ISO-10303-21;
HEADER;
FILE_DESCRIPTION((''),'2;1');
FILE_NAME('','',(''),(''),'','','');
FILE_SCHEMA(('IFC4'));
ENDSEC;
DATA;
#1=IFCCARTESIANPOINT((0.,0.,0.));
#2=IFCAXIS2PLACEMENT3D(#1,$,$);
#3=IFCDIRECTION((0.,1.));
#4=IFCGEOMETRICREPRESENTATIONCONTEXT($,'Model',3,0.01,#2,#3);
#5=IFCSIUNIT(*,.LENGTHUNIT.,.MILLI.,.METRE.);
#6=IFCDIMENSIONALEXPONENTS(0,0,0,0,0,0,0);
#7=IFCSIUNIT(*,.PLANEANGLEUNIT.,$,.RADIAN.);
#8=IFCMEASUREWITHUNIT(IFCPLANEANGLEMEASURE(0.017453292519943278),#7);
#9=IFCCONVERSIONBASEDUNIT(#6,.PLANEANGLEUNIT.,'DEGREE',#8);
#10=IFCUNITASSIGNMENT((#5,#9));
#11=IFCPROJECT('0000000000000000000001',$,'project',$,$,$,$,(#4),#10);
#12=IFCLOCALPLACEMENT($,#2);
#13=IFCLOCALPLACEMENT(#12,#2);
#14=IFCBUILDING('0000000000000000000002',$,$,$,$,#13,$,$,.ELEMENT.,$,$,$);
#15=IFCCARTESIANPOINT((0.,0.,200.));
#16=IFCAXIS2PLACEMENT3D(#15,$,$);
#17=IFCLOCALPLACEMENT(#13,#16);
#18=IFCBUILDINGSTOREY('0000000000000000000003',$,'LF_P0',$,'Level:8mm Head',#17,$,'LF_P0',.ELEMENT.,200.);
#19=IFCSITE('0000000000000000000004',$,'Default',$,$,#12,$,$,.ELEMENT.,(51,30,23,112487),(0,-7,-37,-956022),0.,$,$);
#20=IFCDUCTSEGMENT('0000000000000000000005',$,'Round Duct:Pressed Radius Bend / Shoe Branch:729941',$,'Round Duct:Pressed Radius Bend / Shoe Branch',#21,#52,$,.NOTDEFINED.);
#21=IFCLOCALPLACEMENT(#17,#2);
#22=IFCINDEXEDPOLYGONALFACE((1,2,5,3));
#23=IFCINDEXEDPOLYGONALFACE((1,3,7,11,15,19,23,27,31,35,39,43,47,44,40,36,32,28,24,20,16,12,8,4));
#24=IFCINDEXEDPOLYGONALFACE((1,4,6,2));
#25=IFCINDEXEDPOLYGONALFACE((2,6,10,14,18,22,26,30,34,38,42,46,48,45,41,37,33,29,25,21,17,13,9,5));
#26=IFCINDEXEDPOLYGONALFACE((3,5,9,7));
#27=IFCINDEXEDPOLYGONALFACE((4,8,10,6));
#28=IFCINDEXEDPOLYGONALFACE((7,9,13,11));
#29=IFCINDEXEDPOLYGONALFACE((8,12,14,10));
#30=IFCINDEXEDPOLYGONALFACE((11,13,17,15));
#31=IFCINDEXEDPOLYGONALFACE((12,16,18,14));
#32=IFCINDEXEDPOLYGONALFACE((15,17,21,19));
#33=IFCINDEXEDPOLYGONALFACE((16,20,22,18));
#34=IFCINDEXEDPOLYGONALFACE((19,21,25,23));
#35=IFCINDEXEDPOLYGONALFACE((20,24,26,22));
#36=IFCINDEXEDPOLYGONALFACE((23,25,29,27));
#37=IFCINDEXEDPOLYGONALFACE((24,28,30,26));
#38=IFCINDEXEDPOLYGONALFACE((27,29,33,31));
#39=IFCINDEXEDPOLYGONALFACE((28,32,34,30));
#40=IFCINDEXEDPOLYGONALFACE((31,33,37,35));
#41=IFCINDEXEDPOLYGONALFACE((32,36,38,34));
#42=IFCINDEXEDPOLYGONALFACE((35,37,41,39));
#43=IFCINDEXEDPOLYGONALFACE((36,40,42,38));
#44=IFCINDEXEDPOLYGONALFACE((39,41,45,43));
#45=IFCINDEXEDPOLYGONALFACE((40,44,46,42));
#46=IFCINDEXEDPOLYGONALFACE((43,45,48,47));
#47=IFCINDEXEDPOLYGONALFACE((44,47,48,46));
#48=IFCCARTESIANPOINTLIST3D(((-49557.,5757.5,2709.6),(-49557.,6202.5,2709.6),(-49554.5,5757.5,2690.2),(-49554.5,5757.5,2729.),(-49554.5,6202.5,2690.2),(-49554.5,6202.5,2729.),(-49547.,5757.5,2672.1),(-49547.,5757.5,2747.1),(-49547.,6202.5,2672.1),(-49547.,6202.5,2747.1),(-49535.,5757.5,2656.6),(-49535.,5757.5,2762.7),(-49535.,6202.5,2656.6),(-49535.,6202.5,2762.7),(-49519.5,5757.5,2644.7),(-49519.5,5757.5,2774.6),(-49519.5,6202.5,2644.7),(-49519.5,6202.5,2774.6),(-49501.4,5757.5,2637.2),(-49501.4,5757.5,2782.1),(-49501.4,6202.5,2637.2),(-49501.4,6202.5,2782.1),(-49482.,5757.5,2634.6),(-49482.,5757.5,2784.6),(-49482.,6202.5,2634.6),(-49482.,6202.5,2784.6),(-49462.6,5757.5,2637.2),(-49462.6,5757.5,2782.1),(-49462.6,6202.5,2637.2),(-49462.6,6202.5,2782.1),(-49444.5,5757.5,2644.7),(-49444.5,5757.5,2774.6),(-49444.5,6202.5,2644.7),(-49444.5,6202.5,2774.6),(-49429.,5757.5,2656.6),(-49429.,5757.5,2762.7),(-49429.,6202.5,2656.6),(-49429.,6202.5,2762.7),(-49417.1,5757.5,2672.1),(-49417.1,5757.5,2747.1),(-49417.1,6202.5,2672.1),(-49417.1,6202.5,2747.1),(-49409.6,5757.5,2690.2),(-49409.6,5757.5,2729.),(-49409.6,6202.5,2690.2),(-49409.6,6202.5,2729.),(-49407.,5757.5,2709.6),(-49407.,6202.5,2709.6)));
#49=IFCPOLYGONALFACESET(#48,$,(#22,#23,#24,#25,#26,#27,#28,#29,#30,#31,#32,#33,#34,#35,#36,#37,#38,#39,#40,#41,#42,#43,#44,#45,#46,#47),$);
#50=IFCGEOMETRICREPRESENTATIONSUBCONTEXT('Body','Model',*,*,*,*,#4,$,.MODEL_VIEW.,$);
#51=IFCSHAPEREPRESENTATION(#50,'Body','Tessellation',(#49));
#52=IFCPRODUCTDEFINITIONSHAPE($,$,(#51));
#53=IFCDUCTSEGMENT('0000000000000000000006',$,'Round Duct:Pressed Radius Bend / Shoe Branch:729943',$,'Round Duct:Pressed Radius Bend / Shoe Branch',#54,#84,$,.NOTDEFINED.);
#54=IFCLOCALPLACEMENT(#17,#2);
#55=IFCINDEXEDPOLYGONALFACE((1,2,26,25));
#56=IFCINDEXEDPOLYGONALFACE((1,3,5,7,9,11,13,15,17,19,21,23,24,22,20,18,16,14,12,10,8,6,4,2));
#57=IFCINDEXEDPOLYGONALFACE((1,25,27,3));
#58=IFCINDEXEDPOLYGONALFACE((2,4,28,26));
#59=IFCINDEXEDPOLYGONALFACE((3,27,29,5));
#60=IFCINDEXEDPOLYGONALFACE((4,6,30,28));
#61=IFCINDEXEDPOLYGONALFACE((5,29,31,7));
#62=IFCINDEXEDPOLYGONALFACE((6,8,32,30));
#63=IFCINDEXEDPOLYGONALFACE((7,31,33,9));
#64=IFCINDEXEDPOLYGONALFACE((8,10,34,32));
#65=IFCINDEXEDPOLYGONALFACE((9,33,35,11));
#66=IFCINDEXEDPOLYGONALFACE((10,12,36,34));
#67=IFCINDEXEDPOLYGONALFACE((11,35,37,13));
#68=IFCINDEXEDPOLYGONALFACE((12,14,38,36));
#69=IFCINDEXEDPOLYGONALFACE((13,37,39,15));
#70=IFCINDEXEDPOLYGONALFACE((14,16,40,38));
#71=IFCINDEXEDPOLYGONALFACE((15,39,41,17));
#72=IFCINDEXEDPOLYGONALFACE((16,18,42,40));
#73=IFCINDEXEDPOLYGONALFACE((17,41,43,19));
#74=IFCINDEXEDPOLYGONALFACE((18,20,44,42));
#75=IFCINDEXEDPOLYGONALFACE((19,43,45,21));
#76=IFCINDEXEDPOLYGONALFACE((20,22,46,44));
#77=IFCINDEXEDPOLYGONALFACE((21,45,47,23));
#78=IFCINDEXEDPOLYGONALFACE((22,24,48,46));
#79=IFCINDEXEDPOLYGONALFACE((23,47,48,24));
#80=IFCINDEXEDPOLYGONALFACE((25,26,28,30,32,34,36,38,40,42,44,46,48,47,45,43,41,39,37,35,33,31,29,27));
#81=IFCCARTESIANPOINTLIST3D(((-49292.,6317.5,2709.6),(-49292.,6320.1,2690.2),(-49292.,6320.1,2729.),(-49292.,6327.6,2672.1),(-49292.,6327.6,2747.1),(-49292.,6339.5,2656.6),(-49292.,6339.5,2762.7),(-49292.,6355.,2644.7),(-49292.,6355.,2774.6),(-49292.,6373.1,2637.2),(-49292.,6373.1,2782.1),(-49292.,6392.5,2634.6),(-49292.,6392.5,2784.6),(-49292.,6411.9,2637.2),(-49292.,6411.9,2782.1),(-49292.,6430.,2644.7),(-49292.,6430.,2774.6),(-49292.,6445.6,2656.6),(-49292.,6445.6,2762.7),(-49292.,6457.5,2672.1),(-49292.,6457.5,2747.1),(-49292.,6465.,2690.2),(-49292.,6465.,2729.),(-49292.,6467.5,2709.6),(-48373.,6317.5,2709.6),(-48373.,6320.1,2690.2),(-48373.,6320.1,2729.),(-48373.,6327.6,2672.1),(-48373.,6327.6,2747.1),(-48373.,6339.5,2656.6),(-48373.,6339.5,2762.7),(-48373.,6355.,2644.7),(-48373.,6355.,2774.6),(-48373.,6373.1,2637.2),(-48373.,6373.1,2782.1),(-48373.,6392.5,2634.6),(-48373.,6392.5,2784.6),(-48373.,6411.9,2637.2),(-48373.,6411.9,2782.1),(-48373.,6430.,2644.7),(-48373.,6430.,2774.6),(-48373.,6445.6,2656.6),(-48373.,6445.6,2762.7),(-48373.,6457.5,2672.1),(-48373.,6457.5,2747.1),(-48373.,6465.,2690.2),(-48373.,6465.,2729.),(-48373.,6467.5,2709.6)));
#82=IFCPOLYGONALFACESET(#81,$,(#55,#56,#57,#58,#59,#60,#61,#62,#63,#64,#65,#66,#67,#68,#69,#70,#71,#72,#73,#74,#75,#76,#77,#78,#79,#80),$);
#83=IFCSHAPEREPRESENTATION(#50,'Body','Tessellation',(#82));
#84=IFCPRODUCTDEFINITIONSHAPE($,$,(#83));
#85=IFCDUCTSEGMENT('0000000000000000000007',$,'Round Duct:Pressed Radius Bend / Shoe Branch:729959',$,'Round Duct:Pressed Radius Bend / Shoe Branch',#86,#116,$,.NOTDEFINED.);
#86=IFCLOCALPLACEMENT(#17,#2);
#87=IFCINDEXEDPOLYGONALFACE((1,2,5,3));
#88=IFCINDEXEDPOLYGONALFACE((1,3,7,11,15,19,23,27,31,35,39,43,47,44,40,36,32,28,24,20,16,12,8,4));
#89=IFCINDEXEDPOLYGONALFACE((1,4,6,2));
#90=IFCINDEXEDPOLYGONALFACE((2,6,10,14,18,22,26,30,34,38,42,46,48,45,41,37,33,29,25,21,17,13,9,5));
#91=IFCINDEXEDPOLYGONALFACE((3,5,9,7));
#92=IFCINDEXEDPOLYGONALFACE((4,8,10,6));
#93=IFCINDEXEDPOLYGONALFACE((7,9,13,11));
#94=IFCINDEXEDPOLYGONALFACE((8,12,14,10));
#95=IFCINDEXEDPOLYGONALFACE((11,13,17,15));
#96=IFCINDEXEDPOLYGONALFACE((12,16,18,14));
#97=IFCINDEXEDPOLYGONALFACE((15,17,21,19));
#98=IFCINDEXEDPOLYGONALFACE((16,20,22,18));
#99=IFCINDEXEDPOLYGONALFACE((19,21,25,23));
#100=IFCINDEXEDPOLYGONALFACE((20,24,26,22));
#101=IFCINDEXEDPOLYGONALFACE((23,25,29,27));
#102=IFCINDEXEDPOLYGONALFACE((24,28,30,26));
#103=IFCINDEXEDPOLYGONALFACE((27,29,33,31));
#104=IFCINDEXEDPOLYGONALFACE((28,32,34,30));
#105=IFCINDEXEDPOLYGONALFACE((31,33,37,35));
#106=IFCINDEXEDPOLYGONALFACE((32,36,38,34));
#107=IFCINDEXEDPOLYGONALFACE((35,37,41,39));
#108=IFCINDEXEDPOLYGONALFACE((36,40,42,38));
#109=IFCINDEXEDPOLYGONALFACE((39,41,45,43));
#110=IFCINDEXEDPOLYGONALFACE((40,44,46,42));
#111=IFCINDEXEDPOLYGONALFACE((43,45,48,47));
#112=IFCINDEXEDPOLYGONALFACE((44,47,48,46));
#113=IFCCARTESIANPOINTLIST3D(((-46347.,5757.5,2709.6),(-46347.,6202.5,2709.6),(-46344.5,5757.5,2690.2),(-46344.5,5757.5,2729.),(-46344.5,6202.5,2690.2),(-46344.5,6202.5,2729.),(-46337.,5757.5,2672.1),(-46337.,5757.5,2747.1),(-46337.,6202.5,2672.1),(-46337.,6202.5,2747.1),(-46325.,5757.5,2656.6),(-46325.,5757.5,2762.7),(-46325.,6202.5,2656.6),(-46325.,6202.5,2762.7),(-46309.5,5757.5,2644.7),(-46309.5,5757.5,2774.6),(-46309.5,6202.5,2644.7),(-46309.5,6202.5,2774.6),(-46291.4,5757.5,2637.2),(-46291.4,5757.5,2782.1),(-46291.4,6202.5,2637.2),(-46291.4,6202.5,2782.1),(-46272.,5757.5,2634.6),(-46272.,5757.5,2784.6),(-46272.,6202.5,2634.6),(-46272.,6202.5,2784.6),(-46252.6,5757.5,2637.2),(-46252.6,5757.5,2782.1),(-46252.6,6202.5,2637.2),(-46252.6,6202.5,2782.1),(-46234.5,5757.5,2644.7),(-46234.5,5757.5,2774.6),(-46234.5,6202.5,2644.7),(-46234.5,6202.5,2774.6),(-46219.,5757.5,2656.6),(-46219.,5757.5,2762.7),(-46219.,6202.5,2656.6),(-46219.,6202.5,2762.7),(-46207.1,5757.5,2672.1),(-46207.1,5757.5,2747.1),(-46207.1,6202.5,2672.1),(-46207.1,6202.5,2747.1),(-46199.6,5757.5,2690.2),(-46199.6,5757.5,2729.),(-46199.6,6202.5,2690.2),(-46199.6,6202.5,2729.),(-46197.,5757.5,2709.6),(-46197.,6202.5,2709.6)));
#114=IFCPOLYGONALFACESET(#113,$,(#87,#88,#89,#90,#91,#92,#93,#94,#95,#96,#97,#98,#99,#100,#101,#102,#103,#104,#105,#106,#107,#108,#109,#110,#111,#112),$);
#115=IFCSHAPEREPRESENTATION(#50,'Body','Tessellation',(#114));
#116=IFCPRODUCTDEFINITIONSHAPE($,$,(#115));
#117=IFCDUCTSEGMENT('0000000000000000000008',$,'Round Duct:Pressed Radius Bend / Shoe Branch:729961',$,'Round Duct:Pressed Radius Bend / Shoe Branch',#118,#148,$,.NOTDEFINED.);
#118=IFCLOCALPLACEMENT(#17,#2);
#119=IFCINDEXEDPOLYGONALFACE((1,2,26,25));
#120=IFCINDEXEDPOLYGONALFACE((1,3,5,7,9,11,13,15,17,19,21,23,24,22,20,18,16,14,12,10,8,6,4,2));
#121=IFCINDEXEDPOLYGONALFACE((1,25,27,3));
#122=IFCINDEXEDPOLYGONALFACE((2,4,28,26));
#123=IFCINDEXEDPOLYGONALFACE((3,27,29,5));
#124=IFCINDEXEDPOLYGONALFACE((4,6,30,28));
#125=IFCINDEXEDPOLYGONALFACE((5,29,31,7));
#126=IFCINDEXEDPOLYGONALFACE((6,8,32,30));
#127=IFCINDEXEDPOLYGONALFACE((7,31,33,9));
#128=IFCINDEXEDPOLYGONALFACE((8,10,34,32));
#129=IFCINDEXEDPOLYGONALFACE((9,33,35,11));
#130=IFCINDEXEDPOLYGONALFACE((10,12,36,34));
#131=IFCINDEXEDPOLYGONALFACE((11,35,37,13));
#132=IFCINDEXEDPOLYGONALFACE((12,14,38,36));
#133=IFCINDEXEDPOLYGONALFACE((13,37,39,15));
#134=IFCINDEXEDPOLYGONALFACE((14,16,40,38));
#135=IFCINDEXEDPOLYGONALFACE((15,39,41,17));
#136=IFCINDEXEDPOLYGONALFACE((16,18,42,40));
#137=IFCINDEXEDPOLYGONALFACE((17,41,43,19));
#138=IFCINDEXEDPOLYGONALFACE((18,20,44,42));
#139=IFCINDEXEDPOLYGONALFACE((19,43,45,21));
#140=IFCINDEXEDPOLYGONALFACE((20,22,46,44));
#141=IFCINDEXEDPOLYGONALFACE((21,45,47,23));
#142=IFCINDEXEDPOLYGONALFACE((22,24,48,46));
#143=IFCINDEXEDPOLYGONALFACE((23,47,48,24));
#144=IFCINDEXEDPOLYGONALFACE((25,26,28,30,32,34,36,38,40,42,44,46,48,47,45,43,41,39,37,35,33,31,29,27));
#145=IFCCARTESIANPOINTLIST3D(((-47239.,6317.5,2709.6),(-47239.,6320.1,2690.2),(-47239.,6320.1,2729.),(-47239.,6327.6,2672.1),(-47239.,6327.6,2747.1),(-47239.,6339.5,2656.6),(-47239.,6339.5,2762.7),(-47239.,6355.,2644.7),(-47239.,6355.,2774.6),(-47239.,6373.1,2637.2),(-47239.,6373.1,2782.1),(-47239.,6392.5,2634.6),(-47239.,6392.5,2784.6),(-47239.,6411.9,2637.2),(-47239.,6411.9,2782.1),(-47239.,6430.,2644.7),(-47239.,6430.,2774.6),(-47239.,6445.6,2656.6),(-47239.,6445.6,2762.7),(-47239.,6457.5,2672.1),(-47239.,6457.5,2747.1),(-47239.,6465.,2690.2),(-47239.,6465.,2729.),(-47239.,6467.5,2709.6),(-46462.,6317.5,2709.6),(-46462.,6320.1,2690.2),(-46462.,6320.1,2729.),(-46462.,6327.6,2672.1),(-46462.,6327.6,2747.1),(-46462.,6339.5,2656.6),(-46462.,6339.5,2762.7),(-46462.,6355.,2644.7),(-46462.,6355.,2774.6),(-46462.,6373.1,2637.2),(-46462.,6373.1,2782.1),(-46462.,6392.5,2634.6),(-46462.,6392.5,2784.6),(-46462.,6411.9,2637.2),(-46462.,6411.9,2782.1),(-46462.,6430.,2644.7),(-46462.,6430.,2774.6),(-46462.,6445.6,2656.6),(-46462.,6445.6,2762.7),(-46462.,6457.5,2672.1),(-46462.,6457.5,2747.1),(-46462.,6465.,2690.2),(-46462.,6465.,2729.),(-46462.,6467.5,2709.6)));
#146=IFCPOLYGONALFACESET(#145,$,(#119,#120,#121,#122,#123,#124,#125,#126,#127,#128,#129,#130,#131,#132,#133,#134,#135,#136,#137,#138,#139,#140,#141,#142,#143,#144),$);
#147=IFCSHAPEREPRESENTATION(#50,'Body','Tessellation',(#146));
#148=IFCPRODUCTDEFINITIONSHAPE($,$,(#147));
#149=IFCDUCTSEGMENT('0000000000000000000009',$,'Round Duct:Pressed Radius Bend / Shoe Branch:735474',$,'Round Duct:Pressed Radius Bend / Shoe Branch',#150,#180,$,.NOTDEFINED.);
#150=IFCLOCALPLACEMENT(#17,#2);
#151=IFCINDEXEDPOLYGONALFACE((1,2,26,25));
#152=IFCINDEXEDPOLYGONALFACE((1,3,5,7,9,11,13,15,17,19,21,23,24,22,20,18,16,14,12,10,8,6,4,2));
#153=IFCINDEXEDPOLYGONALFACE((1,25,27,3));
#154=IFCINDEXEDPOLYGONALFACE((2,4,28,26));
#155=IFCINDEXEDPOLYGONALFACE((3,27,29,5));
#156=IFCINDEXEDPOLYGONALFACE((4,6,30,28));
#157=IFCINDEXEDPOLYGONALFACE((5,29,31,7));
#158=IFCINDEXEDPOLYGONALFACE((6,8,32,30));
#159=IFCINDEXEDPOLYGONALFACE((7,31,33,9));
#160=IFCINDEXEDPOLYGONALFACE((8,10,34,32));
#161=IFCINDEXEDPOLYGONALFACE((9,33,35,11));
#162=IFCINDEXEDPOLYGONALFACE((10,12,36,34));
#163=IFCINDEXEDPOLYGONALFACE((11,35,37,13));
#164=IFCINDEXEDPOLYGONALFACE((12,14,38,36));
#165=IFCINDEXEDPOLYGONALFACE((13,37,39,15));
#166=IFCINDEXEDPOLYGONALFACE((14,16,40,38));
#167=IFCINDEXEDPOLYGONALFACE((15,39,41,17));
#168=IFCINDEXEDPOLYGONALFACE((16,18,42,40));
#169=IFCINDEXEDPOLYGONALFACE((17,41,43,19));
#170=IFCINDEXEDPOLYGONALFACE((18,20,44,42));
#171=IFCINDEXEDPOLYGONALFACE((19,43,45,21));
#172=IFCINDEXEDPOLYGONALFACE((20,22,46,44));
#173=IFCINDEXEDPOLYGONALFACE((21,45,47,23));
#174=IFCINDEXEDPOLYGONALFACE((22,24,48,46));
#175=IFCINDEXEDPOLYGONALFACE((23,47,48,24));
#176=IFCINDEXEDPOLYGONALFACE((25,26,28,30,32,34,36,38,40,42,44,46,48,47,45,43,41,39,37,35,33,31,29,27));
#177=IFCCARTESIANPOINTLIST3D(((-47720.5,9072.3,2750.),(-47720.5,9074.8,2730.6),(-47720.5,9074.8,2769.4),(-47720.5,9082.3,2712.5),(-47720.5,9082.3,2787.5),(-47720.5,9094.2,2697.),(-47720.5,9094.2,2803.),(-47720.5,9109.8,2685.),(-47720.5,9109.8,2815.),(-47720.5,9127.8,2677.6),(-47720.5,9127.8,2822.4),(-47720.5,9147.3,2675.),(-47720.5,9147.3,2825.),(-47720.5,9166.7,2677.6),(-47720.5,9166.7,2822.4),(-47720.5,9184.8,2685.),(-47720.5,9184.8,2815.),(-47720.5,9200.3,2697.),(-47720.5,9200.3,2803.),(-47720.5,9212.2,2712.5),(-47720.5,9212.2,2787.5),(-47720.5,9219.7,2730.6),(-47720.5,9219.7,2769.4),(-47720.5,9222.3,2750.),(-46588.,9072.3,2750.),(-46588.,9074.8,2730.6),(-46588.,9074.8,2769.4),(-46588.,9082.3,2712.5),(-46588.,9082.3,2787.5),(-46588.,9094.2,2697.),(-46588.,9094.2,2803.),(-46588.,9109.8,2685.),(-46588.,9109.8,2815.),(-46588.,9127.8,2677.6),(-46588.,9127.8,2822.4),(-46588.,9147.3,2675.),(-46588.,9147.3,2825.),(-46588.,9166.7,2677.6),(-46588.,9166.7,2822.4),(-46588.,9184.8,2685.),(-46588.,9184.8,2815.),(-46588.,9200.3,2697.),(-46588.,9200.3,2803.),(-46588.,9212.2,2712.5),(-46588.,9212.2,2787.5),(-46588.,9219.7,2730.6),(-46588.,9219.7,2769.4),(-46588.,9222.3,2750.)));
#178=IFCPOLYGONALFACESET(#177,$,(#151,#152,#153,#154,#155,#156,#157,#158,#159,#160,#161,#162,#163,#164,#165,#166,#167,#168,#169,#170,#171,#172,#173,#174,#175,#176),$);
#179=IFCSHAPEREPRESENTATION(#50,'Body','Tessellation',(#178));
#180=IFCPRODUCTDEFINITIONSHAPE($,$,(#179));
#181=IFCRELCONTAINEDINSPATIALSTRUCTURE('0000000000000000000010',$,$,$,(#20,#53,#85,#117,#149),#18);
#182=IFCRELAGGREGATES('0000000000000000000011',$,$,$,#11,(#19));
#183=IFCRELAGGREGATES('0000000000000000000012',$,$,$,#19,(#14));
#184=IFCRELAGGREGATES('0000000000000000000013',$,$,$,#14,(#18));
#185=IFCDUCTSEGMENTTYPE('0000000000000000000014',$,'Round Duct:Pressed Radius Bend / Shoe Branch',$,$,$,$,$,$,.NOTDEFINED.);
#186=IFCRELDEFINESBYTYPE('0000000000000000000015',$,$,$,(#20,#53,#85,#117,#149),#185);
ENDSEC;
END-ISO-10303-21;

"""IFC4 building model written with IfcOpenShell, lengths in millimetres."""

from ifc_helpers import new_model, entity, si_unit, converted_unit, direction, frame, origin, place, context, subcontext, project, spatial, arc, indexed_curve, outline, extrude, type_object, element, save


model = new_model("IFC4")

# Units and contexts
model_context = context("Model", 3, precision=0.01, world=origin(), true_north=direction((0.0, 1.0)))
body_context = subcontext(model_context, "Body", "Model", "MODEL_VIEW")
ifc_project = project(units=[si_unit("LENGTHUNIT", "METRE", prefix="MILLI"), converted_unit("PLANEANGLEUNIT", "DEGREE", entity("IfcPlaneAngleMeasure", 0.017453292519943278), si_unit("PLANEANGLEUNIT", "RADIAN"), dimensions=[0, 0, 0, 0, 0, 0, 0])], contexts=[model_context])

# Site, building, storey
site_placement = place(None, origin())
site = spatial("IfcSite", under=ifc_project, at=site_placement, Name="Default", CompositionType="ELEMENT", RefLatitude=(51, 30, 23, 112487), RefLongitude=(0, -7, -37, -956022), RefElevation=0.0)
building_placement = place(site_placement, origin())
building = spatial("IfcBuilding", under=site, at=building_placement, CompositionType="ELEMENT")
storey_placement = place(building_placement, frame((0.0, 0.0, 200.0)))
storey = spatial("IfcBuildingStorey", under=building, at=storey_placement, Name="LF_P0", ObjectType="Level:8mm Head", LongName="LF_P0", CompositionType="ELEMENT", Elevation=200.0)

# Duct segments
duct_segment_type_1 = type_object("IfcDuctSegmentType", Name="Round Duct:Pressed Radius Bend / Shoe Branch", PredefinedType="NOTDEFINED")
duct_segment_1_placement = place(storey_placement, origin())
element("IfcDuctSegment", 1, at=duct_segment_1_placement, inside=storey, type_object=duct_segment_type_1, Name="Round Duct:Pressed Radius Bend / Shoe Branch:729941", ObjectType="Round Duct:Pressed Radius Bend / Shoe Branch", PredefinedType="NOTDEFINED", context=body_context, shape_type="SweptSolid", body=[
    extrude(outline(indexed_curve([(75.0, 0.0), (53.0, 53.0), (0.0, 75.0), (-53.0, 53.0), (-75.0, 0.0), (-53.0, -53.0), (0.0, -75.0), (53.0, -53.0)], segments=[arc(1, 2, 3), arc(3, 4, 5), arc(5, 6, 7), arc(7, 8, 1)], self_intersect=False)), frame((-49482.0, 5757.5, 2709.6), z_axis=(0.0, 1.0, 0.0), x_axis=(1.0, 0.0, 0.0)), (0.0, 0.0, 1.0), 445.0),
])
duct_segment_2_placement = place(storey_placement, origin())
element("IfcDuctSegment", 2, at=duct_segment_2_placement, inside=storey, type_object=duct_segment_type_1, Name="Round Duct:Pressed Radius Bend / Shoe Branch:729943", ObjectType="Round Duct:Pressed Radius Bend / Shoe Branch", PredefinedType="NOTDEFINED", context=body_context, shape_type="SweptSolid", body=[
    extrude(outline(indexed_curve([(75.0, 0.0), (53.0, 53.0), (0.0, 75.0), (-53.0, 53.0), (-75.0, 0.0), (-53.0, -53.0), (0.0, -75.0), (53.0, -53.0)], segments=[arc(1, 2, 3), arc(3, 4, 5), arc(5, 6, 7), arc(7, 8, 1)], self_intersect=False)), frame((-49292.0, 6392.5, 2709.6), z_axis=(1.0, 0.0, 0.0), x_axis=(0.0, 1.0, 0.0)), (0.0, 0.0, 1.0), 919.0),
])
duct_segment_3_placement = place(storey_placement, origin())
element("IfcDuctSegment", 3, at=duct_segment_3_placement, inside=storey, type_object=duct_segment_type_1, Name="Round Duct:Pressed Radius Bend / Shoe Branch:729959", ObjectType="Round Duct:Pressed Radius Bend / Shoe Branch", PredefinedType="NOTDEFINED", context=body_context, shape_type="SweptSolid", body=[
    extrude(outline(indexed_curve([(75.0, 0.0), (53.0, 53.0), (0.0, 75.0), (-53.0, 53.0), (-75.0, 0.0), (-53.0, -53.0), (0.0, -75.0), (53.0, -53.0)], segments=[arc(1, 2, 3), arc(3, 4, 5), arc(5, 6, 7), arc(7, 8, 1)], self_intersect=False)), frame((-46272.0, 5757.5, 2709.6), z_axis=(0.0, 1.0, 0.0), x_axis=(1.0, 0.0, 0.0)), (0.0, 0.0, 1.0), 445.0),
])
duct_segment_4_placement = place(storey_placement, origin())
element("IfcDuctSegment", 4, at=duct_segment_4_placement, inside=storey, type_object=duct_segment_type_1, Name="Round Duct:Pressed Radius Bend / Shoe Branch:729961", ObjectType="Round Duct:Pressed Radius Bend / Shoe Branch", PredefinedType="NOTDEFINED", context=body_context, shape_type="SweptSolid", body=[
    extrude(outline(indexed_curve([(75.0, 0.0), (53.0, 53.0), (0.0, 75.0), (-53.0, 53.0), (-75.0, 0.0), (-53.0, -53.0), (0.0, -75.0), (53.0, -53.0)], segments=[arc(1, 2, 3), arc(3, 4, 5), arc(5, 6, 7), arc(7, 8, 1)], self_intersect=False)), frame((-47239.0, 6392.5, 2709.6), z_axis=(1.0, 0.0, 0.0), x_axis=(0.0, -1.0, 0.0)), (0.0, 0.0, 1.0), 777.0),
])
duct_segment_5_placement = place(storey_placement, origin())
element("IfcDuctSegment", 5, at=duct_segment_5_placement, inside=storey, type_object=duct_segment_type_1, Name="Round Duct:Pressed Radius Bend / Shoe Branch:735474", ObjectType="Round Duct:Pressed Radius Bend / Shoe Branch", PredefinedType="NOTDEFINED", context=body_context, shape_type="SweptSolid", body=[
    extrude(outline(indexed_curve([(75.0, 0.0), (53.0, 53.0), (0.0, 75.0), (-53.0, 53.0), (-75.0, 0.0), (-53.0, -53.0), (0.0, -75.0), (53.0, -53.0)], segments=[arc(1, 2, 3), arc(3, 4, 5), arc(5, 6, 7), arc(7, 8, 1)], self_intersect=False)), frame((-47720.5, 9147.3, 2750.0), z_axis=(1.0, 0.0, 0.0), x_axis=(0.0, 1.0, 0.0)), (0.0, 0.0, 1.0), 1132.5),
])

save(model, "model.ifc")
